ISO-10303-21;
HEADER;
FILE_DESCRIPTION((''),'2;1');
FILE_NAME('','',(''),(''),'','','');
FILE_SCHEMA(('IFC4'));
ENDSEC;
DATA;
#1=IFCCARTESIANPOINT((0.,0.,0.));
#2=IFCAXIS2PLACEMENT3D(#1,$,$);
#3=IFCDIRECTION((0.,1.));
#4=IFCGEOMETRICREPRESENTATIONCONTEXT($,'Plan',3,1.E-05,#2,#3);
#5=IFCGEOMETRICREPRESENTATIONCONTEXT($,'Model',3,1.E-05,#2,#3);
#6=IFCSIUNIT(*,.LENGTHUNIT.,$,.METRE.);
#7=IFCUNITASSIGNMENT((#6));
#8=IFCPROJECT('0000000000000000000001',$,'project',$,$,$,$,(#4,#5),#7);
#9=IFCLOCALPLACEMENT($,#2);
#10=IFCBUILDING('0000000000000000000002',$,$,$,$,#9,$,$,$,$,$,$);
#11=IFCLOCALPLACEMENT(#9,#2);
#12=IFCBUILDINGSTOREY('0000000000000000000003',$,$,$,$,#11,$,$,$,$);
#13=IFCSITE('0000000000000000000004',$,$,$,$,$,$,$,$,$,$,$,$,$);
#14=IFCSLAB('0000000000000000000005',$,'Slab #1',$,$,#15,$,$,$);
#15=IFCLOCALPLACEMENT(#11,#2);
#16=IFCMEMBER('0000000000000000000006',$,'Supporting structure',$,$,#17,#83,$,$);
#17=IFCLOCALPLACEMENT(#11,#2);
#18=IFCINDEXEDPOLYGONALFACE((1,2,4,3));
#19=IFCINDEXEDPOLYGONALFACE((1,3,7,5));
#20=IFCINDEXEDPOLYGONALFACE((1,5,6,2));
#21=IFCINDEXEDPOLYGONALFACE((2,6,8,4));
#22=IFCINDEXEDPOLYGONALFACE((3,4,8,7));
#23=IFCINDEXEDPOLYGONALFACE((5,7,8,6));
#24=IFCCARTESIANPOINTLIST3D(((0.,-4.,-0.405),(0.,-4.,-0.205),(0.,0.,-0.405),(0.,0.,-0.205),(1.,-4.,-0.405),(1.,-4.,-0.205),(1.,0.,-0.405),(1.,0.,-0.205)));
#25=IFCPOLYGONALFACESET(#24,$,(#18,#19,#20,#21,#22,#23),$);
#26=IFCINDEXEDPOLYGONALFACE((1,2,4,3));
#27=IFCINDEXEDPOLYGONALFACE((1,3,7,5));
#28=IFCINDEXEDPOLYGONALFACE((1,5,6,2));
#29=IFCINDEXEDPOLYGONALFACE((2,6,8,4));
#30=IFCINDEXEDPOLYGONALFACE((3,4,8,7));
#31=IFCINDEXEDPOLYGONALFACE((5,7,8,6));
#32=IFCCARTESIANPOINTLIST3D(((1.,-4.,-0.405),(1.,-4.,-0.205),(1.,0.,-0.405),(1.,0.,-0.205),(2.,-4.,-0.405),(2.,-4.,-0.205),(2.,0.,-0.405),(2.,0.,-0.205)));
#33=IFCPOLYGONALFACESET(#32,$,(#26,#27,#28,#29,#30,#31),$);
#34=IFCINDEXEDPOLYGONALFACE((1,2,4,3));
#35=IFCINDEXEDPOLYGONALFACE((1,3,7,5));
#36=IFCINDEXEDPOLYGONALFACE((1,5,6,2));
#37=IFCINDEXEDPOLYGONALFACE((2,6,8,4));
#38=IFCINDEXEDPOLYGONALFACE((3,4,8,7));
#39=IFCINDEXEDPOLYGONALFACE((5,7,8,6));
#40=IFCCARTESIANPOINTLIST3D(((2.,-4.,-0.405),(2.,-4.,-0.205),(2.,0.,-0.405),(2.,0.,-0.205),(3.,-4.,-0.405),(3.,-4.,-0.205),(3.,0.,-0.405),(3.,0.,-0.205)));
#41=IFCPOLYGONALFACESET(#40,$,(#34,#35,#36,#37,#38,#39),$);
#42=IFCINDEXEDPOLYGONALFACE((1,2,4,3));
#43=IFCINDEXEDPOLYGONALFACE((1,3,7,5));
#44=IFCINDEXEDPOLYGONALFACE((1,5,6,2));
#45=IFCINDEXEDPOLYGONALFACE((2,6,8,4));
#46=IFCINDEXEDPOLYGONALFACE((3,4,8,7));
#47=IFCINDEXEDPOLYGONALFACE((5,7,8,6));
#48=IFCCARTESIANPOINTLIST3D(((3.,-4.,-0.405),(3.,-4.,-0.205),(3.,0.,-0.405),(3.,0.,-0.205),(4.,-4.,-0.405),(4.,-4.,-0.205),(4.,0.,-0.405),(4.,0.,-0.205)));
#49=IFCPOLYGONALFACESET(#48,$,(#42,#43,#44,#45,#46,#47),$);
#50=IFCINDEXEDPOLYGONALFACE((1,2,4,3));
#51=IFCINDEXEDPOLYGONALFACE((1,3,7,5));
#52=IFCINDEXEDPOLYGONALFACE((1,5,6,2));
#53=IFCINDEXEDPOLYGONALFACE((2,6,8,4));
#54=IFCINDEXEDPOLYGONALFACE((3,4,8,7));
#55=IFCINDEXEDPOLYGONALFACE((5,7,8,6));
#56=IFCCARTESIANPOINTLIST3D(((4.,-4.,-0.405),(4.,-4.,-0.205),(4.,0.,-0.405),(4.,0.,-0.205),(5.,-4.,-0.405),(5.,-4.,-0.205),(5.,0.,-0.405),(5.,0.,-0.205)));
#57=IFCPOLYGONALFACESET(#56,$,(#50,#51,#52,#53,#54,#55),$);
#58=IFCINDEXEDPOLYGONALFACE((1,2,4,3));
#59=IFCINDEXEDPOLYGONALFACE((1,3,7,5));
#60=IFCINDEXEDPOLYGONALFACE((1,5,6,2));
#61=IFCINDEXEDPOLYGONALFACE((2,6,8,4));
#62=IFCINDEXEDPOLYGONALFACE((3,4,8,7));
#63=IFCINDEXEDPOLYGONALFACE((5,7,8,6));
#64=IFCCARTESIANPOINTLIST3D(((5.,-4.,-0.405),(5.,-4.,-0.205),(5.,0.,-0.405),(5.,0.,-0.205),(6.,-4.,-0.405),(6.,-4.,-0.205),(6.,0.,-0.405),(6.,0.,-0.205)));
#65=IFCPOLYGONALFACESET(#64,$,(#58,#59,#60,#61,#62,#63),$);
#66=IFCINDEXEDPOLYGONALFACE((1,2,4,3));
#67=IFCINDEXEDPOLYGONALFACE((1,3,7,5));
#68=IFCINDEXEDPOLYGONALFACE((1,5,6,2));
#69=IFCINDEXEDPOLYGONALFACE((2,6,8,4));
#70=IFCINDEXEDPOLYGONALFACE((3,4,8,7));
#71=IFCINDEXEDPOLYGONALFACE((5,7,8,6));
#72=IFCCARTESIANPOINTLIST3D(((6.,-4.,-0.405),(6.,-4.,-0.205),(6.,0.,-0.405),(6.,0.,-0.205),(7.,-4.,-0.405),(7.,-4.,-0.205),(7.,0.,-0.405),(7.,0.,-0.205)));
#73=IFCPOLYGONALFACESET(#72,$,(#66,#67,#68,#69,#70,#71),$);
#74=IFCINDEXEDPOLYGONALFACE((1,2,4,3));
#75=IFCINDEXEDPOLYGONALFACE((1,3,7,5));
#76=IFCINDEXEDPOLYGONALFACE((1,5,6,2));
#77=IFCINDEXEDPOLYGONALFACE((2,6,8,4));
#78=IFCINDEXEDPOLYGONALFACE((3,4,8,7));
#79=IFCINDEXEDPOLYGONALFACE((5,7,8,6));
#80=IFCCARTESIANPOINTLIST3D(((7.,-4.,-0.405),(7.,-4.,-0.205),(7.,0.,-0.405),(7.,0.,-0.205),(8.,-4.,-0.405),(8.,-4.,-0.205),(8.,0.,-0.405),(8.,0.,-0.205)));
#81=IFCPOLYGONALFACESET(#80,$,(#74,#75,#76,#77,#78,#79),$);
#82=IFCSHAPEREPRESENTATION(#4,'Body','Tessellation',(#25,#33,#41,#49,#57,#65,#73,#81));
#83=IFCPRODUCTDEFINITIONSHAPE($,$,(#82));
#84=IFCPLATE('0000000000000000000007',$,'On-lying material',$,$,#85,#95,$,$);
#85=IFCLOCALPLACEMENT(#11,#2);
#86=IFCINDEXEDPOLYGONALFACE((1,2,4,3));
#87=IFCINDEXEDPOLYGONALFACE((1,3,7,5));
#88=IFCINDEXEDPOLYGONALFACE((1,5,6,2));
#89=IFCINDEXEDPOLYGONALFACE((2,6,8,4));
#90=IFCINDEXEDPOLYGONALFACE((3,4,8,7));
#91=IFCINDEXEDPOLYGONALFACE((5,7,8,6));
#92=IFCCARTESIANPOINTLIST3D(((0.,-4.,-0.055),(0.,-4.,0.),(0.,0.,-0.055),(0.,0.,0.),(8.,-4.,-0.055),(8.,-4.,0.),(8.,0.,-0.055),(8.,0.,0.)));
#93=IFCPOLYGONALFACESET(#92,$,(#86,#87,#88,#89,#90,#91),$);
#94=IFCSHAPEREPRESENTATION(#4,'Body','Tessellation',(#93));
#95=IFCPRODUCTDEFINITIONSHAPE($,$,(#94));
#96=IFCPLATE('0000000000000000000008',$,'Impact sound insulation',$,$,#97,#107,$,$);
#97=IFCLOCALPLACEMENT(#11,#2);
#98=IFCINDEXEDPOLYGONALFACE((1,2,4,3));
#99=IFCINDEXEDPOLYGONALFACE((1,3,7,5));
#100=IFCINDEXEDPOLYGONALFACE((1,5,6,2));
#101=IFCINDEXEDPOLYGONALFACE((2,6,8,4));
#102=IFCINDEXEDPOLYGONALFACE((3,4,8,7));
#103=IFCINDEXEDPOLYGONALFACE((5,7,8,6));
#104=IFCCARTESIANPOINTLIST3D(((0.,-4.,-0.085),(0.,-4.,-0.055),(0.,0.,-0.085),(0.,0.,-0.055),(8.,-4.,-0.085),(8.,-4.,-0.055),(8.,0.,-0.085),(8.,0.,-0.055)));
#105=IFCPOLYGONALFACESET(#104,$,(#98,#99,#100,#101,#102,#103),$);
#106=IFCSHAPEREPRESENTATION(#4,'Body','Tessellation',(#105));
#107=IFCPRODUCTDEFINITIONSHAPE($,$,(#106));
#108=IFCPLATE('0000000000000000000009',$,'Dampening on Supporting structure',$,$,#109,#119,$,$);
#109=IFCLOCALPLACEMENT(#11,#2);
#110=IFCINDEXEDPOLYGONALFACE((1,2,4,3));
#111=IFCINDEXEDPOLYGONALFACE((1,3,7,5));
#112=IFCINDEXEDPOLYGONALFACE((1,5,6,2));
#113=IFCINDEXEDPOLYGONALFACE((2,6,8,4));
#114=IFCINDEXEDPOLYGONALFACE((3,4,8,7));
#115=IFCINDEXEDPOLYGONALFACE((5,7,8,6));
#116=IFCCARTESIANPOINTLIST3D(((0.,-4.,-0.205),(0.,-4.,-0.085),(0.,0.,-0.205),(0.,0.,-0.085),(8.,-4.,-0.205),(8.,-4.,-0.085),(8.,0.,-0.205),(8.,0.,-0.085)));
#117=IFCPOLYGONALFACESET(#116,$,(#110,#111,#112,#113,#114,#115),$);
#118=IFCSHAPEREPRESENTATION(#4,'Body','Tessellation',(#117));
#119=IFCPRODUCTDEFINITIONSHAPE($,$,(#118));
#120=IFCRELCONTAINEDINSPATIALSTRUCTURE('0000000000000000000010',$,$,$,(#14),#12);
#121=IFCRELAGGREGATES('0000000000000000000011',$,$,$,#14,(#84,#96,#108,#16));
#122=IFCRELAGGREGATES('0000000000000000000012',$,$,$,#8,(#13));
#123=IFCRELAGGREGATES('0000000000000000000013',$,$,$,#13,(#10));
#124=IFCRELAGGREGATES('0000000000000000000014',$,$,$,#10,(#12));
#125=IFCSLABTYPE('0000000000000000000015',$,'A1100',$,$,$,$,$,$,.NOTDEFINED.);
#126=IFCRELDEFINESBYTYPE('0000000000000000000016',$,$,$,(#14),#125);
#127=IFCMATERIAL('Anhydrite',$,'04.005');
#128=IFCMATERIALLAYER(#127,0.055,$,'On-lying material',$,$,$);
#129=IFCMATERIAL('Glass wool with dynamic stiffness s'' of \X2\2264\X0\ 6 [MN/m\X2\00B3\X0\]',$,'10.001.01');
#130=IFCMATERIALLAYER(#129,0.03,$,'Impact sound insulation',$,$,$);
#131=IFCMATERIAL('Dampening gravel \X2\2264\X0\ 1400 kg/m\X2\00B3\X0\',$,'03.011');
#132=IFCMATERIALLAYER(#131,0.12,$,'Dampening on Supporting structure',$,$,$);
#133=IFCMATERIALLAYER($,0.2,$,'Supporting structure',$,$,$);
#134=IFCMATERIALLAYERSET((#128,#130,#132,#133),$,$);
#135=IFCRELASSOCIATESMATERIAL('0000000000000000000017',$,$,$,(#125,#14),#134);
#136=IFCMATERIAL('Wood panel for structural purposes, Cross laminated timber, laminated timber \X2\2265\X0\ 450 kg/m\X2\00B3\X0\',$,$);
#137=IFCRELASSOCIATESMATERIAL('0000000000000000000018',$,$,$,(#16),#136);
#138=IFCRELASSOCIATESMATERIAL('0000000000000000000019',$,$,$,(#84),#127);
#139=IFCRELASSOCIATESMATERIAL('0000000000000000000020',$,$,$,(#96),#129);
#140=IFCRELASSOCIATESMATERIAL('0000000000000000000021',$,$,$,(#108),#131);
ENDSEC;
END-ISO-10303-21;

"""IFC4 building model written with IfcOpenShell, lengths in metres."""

from ifc_helpers import new_model, si_unit, direction, frame, frame_2d, origin, origin_with_axes, place, context, project, spatial, rectangle, extrude, material, layer, layer_set, type_object, element, aggregate, save


model = new_model("IFC4")

# Units and contexts
plan_context = context("Plan", 3, precision=1e-05, world=origin(), true_north=direction((0.0, 1.0)))
model_context = context("Model", 3, precision=1e-05, world=origin(), true_north=direction((0.0, 1.0)))
ifc_project = project(units=[si_unit("LENGTHUNIT", "METRE")], contexts=[plan_context, model_context])

# Site, building, storey
site = spatial("IfcSite", under=ifc_project)
building_placement = place(None, origin())
building = spatial("IfcBuilding", under=site, at=building_placement)
storey_placement = place(building_placement, origin())
storey = spatial("IfcBuildingStorey", under=building, at=storey_placement)

# Slab, member, plates
ifc_material_1 = material(Name="Anhydrite", Category="04.005")
ifc_layer_1 = layer(ifc_material_1, 0.055, Name="On-lying material")
ifc_material_2 = material(Name="Glass wool with dynamic stiffness s' of ≤ 6 [MN/m³]", Category="10.001.01")
ifc_layer_2 = layer(ifc_material_2, 0.03, Name="Impact sound insulation")
ifc_material_3 = material(Name="Dampening gravel ≤ 1400 kg/m³", Category="03.011")
ifc_layer_3 = layer(ifc_material_3, 0.12, Name="Dampening on Supporting structure")
ifc_layer_4 = layer(None, 0.2, Name="Supporting structure")
ifc_layer_set = layer_set([ifc_layer_1, ifc_layer_2, ifc_layer_3, ifc_layer_4])
slab_type = type_object("IfcSlabType", Name="A1100", PredefinedType="NOTDEFINED", material=ifc_layer_set)
slab_placement = place(None, frame((0.0, 0.0, 0.0), z_axis=(0.0, 0.0, -1.0), x_axis=(1.0, 0.0, 0.0)))
slab = element("IfcSlab", 1, at=slab_placement, inside=storey, type_object=slab_type, material=ifc_layer_set, Name="Slab #1")
ifc_material_4 = material(Name="Wood panel for structural purposes, Cross laminated timber, laminated timber ≥ 450 kg/m³")
member_placement = place(slab_placement, origin())
member = element("IfcMember", 2, at=member_placement, material=ifc_material_4, Name="Supporting structure", context=plan_context, shape_type="SweptSolid", body=[
    extrude(rectangle(XDim=1.0, YDim=0.2, at=frame_2d((0.5, 0.1), x_axis=(1.0, 0.0))), frame((0.0, 4.0, 0.205), z_axis=(0.0, -1.0, 0.0), x_axis=(1.0, 0.0, 0.0)), (0.0, 0.0, 1.0), 4.0),
    extrude(rectangle(XDim=1.0, YDim=0.2, at=frame_2d((0.5, 0.1), x_axis=(1.0, 0.0))), frame((1.0, 4.0, 0.205), z_axis=(0.0, -1.0, 0.0), x_axis=(1.0, 0.0, 0.0)), (0.0, 0.0, 1.0), 4.0),
    extrude(rectangle(XDim=1.0, YDim=0.2, at=frame_2d((0.5, 0.1), x_axis=(1.0, 0.0))), frame((2.0, 4.0, 0.205), z_axis=(0.0, -1.0, 0.0), x_axis=(1.0, 0.0, 0.0)), (0.0, 0.0, 1.0), 4.0),
    extrude(rectangle(XDim=1.0, YDim=0.2, at=frame_2d((0.5, 0.1), x_axis=(1.0, 0.0))), frame((3.0, 4.0, 0.205), z_axis=(0.0, -1.0, 0.0), x_axis=(1.0, 0.0, 0.0)), (0.0, 0.0, 1.0), 4.0),
    extrude(rectangle(XDim=1.0, YDim=0.2, at=frame_2d((0.5, 0.1), x_axis=(1.0, 0.0))), frame((4.0, 4.0, 0.205), z_axis=(0.0, -1.0, 0.0), x_axis=(1.0, 0.0, 0.0)), (0.0, 0.0, 1.0), 4.0),
    extrude(rectangle(XDim=1.0, YDim=0.2, at=frame_2d((0.5, 0.1), x_axis=(1.0, 0.0))), frame((5.0, 4.0, 0.205), z_axis=(0.0, -1.0, 0.0), x_axis=(1.0, 0.0, 0.0)), (0.0, 0.0, 1.0), 4.0),
    extrude(rectangle(XDim=1.0, YDim=0.2, at=frame_2d((0.5, 0.1), x_axis=(1.0, 0.0))), frame((6.0, 4.0, 0.205), z_axis=(0.0, -1.0, 0.0), x_axis=(1.0, 0.0, 0.0)), (0.0, 0.0, 1.0), 4.0),
    extrude(rectangle(XDim=1.0, YDim=0.2, at=frame_2d((0.5, 0.1), x_axis=(1.0, 0.0))), frame((7.0, 4.0, 0.205), z_axis=(0.0, -1.0, 0.0), x_axis=(1.0, 0.0, 0.0)), (0.0, 0.0, 1.0), 4.0),
])
plate_1_placement = place(slab_placement, origin())
plate_1 = element("IfcPlate", 3, at=plate_1_placement, material=ifc_material_1, Name="On-lying material", context=plan_context, shape_type="SweptSolid", body=[
    extrude(rectangle(XDim=8.0, YDim=4.0, at=frame_2d((4.0, 2.0), x_axis=(1.0, 0.0))), origin_with_axes(), (0.0, 0.0, 1.0), 0.055),
])
plate_2_placement = place(slab_placement, origin())
plate_2 = element("IfcPlate", 4, at=plate_2_placement, material=ifc_material_2, Name="Impact sound insulation", context=plan_context, shape_type="SweptSolid", body=[
    extrude(rectangle(XDim=8.0, YDim=4.0, at=frame_2d((4.0, 2.0), x_axis=(1.0, 0.0))), frame((0.0, 0.0, 0.055), z_axis=(0.0, 0.0, 1.0), x_axis=(1.0, 0.0, 0.0)), (0.0, 0.0, 1.0), 0.03),
])
plate_3_placement = place(slab_placement, origin())
plate_3 = element("IfcPlate", 5, at=plate_3_placement, material=ifc_material_3, Name="Dampening on Supporting structure", context=plan_context, shape_type="SweptSolid", body=[
    extrude(rectangle(XDim=8.0, YDim=4.0, at=frame_2d((4.0, 2.0), x_axis=(1.0, 0.0))), frame((0.0, 0.0, 0.085), z_axis=(0.0, 0.0, 1.0), x_axis=(1.0, 0.0, 0.0)), (0.0, 0.0, 1.0), 0.12),
])
aggregate(slab, [plate_1, plate_2, plate_3, member])

save(model, "model.ifc")
